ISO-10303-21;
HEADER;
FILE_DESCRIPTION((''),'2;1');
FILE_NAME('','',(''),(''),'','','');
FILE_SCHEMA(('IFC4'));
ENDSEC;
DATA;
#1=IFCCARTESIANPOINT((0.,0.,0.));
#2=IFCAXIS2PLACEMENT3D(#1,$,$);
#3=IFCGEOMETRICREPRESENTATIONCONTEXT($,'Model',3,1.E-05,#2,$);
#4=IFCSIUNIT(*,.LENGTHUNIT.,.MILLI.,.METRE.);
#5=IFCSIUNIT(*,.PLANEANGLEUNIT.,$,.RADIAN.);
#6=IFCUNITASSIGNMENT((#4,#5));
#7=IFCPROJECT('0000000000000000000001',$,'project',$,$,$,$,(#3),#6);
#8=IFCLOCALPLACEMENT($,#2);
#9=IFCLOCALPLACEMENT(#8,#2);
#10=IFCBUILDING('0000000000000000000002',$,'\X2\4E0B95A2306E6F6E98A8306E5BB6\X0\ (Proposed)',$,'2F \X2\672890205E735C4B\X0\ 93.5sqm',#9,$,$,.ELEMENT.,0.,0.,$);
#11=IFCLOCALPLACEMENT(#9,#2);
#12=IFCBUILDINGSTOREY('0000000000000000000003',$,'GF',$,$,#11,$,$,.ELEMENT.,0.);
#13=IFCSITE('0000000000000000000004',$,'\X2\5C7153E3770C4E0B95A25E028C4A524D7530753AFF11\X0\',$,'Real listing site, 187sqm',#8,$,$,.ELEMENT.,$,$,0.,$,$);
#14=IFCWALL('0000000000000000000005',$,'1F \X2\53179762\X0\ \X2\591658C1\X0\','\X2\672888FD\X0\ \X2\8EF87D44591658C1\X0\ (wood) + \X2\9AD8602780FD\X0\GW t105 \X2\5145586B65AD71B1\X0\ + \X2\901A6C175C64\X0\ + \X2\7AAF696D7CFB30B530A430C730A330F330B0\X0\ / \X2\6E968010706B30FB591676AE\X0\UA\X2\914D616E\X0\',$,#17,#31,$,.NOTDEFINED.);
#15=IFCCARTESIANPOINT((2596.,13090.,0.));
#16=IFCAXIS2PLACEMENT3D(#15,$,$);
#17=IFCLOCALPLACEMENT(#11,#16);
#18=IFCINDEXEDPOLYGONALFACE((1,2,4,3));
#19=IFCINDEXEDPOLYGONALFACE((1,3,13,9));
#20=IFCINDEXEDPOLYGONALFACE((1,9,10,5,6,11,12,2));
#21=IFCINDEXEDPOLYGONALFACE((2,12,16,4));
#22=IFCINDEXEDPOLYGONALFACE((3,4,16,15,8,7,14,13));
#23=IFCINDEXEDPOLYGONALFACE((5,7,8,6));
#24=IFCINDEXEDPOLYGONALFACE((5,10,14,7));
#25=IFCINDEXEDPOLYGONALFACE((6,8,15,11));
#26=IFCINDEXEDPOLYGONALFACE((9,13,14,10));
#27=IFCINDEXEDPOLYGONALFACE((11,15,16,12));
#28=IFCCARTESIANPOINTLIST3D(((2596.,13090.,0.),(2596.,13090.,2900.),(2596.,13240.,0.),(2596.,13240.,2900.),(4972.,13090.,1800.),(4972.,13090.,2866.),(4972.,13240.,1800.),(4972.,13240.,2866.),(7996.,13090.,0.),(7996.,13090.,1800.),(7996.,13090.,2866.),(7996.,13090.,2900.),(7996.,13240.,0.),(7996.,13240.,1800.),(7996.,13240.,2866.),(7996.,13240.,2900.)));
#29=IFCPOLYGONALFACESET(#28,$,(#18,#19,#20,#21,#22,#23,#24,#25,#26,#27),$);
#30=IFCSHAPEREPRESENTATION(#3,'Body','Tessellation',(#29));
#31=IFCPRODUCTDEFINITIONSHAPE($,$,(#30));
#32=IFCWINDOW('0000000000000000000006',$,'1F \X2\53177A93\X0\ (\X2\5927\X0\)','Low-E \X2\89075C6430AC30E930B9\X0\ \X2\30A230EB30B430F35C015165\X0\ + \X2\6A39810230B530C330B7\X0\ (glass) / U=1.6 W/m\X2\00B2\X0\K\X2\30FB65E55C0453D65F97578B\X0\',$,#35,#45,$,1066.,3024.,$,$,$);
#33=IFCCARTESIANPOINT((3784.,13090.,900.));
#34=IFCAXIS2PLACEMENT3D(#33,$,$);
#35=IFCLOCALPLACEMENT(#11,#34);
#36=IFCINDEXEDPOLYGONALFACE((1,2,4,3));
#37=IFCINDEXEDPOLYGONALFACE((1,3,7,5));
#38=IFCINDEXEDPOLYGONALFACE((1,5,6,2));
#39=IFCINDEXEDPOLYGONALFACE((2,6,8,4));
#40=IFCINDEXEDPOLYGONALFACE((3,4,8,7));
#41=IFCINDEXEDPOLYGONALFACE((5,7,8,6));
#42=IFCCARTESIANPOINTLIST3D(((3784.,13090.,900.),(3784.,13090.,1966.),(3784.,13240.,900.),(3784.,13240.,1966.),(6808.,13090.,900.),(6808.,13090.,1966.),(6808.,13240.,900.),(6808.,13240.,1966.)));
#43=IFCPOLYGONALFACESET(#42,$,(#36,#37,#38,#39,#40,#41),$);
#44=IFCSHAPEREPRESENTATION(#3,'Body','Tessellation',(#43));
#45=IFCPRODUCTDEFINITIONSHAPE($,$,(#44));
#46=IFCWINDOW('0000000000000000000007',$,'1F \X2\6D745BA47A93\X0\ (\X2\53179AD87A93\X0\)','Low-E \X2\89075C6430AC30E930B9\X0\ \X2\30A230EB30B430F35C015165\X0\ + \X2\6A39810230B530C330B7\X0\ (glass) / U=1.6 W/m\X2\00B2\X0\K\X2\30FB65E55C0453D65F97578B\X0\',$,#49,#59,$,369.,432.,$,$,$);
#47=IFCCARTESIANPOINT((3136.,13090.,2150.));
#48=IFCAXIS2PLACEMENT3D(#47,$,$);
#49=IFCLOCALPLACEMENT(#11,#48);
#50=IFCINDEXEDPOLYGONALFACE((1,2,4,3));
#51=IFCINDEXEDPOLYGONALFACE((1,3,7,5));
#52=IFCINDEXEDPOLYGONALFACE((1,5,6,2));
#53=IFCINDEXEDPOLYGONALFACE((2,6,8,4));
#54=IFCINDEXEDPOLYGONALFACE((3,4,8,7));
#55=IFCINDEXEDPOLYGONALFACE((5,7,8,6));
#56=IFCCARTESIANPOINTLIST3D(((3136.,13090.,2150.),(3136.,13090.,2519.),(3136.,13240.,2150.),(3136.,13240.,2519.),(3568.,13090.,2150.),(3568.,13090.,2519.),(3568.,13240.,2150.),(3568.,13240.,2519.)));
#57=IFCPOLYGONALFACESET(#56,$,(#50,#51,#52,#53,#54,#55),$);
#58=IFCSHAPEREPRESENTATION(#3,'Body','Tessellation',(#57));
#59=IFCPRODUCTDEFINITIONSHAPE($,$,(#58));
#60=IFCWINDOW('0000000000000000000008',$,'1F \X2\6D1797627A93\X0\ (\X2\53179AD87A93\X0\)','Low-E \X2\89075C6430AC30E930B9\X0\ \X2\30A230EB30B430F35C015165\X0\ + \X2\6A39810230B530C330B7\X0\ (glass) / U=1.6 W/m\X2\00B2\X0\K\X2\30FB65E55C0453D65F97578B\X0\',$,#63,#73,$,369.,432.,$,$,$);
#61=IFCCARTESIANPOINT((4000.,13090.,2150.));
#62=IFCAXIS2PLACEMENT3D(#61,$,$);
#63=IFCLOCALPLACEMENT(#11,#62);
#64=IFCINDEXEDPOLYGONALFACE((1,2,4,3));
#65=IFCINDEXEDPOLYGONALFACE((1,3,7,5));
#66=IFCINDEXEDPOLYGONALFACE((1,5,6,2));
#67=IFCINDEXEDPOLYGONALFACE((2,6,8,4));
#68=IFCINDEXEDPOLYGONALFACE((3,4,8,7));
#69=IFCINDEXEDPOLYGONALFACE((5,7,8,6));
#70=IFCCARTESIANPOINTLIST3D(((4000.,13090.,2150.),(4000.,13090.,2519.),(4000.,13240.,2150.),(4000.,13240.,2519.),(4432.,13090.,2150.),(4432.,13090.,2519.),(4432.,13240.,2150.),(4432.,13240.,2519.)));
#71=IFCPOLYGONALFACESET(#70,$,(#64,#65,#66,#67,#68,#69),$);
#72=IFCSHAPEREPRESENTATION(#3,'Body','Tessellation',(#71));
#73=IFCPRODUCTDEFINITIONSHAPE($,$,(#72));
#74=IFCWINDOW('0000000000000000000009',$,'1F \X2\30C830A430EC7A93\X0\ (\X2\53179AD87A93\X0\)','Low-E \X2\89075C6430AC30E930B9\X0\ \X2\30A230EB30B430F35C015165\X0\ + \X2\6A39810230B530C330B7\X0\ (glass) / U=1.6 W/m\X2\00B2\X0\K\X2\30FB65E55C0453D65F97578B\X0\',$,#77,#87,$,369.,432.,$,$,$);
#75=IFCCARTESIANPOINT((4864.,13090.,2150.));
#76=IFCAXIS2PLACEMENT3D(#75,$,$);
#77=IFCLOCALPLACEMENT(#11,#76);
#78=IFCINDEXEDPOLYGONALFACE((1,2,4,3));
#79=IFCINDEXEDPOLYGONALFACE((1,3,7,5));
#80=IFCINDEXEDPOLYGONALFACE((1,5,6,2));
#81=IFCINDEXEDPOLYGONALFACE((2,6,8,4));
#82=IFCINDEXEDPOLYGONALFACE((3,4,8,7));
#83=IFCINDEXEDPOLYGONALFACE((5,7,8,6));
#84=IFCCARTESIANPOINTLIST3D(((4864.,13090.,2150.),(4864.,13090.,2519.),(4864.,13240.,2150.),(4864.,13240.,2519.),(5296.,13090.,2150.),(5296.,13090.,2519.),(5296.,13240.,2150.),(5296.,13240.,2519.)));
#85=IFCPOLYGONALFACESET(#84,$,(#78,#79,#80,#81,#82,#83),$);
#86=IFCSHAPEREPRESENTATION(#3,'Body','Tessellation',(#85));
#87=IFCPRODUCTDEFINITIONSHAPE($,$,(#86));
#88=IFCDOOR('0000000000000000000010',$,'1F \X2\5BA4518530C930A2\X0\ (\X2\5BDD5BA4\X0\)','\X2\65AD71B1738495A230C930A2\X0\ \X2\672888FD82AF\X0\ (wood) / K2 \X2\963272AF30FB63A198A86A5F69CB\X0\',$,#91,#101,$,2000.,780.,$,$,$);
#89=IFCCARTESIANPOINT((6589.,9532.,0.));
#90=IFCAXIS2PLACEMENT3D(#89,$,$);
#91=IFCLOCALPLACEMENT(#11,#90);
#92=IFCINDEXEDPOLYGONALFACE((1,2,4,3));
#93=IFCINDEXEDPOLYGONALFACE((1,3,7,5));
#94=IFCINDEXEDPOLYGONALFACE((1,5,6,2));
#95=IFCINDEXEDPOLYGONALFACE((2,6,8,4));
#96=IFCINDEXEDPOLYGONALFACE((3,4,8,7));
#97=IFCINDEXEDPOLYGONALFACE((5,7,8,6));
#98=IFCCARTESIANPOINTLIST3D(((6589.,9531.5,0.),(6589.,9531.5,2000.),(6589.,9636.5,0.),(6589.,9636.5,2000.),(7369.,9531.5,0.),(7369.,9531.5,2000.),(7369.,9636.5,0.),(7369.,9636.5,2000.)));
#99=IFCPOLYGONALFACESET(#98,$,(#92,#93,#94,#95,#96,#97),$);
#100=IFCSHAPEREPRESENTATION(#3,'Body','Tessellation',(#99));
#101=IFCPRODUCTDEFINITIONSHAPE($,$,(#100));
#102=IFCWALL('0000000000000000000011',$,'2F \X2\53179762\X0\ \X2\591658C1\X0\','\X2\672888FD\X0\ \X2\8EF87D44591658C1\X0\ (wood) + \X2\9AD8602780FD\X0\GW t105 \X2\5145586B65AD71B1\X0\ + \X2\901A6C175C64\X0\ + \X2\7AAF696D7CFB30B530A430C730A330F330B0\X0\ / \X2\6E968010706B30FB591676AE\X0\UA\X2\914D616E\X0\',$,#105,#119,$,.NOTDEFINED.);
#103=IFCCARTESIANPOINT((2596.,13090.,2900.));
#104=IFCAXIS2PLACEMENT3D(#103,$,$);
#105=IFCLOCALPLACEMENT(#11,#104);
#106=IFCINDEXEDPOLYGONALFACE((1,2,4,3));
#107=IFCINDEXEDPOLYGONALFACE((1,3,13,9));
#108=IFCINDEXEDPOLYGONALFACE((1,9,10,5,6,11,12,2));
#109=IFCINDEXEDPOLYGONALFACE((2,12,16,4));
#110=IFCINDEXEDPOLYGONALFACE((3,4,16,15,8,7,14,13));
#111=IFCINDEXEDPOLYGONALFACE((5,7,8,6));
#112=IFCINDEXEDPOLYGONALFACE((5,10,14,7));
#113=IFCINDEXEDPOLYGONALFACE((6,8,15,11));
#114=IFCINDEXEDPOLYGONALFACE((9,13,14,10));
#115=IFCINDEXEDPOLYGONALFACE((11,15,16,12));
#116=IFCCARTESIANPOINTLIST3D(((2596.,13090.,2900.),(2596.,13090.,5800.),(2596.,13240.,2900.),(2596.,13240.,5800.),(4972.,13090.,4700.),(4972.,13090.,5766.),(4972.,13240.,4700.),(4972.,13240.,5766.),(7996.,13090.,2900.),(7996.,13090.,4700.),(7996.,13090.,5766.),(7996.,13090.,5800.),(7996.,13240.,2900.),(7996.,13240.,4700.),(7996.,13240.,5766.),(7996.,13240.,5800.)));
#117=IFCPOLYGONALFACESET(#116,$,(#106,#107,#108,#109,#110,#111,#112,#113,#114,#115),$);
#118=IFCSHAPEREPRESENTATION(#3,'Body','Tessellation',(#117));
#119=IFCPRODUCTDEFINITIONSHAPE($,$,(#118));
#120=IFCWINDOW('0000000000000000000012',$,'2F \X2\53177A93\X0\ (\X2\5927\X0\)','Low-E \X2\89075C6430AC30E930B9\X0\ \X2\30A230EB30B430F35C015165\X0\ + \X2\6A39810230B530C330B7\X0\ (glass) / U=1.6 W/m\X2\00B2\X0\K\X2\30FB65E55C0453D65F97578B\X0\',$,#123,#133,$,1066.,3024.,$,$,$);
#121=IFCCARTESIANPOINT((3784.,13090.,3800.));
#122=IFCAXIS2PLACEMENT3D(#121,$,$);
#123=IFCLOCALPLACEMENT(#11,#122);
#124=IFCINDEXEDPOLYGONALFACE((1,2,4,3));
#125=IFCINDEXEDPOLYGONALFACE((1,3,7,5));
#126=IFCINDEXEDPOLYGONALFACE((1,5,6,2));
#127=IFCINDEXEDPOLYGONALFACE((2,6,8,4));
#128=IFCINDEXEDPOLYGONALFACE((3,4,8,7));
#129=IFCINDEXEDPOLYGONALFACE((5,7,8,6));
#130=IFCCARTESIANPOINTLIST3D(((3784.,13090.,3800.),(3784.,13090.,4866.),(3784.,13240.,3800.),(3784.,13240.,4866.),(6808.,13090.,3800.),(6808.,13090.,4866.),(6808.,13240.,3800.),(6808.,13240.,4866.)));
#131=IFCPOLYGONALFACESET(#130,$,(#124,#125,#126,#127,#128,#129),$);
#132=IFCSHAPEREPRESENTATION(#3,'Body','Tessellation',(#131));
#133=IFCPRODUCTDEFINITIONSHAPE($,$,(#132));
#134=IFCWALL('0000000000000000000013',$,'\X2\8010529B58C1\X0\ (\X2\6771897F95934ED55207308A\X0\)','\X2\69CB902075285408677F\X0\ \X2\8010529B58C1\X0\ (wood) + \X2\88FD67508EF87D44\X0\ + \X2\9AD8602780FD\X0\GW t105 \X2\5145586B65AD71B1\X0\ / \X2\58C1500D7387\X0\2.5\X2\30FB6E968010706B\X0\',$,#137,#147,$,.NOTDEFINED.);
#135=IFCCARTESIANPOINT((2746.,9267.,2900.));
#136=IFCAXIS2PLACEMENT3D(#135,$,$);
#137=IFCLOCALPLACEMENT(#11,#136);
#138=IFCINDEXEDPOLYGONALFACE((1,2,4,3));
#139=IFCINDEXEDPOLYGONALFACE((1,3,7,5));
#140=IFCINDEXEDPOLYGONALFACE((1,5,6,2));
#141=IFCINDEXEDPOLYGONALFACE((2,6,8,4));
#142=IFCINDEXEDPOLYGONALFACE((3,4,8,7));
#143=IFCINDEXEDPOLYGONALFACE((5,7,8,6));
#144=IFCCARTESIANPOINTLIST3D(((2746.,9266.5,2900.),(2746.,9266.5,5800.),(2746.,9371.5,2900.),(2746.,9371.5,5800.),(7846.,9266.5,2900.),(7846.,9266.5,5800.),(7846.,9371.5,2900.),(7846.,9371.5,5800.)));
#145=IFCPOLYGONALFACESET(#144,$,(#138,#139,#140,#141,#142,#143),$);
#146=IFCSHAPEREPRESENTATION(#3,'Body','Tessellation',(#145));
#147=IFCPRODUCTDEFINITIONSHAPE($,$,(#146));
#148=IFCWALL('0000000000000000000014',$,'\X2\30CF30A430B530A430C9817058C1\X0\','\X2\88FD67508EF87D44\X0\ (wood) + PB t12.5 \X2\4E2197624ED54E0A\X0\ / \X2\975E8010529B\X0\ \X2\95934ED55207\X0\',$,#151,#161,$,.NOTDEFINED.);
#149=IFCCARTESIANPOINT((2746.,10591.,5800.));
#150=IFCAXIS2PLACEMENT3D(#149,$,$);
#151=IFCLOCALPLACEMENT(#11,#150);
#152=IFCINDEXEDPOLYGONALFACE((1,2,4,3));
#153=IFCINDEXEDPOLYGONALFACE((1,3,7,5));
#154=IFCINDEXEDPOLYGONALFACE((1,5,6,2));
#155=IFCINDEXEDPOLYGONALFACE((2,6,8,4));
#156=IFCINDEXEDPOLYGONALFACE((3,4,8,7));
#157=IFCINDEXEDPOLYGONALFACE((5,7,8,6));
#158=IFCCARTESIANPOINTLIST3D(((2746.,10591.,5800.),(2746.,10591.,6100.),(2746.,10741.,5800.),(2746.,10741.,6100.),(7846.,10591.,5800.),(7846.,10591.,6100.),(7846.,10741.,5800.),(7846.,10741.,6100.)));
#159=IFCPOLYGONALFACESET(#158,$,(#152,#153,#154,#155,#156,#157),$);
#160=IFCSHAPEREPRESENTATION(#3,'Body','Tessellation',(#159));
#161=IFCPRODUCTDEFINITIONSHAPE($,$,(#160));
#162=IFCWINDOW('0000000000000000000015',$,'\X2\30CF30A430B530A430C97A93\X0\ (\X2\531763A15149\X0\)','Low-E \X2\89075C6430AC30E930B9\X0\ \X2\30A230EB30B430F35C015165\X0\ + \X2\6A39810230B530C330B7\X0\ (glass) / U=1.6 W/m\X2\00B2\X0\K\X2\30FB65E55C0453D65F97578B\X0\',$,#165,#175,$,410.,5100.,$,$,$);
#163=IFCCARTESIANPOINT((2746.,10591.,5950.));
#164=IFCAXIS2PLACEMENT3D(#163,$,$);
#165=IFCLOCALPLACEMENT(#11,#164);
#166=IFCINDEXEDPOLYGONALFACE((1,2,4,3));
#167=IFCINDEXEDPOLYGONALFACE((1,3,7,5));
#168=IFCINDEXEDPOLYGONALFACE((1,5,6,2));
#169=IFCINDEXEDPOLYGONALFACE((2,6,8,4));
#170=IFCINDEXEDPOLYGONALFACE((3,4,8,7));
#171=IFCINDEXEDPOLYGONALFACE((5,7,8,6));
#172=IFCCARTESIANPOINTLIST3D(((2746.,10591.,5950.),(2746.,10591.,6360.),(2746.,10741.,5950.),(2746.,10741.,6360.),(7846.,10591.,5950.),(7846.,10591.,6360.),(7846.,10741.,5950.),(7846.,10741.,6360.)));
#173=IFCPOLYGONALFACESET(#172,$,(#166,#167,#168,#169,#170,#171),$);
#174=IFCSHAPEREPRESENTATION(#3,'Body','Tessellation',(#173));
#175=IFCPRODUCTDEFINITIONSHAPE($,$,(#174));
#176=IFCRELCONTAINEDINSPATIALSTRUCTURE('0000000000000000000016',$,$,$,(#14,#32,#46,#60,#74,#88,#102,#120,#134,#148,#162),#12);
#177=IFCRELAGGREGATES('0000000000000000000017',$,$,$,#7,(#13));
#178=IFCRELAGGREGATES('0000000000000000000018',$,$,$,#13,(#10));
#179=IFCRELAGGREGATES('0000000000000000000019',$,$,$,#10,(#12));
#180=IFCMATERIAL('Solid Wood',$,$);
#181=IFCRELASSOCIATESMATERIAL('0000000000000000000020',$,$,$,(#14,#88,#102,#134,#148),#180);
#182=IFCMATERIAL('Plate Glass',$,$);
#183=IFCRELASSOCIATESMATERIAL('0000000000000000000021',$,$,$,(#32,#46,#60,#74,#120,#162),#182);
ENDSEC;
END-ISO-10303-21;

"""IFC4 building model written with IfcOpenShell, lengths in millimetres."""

from ifc_helpers import new_model, si_unit, frame, frame_2d, origin, place, context, project, spatial, rectangle, extrude, material, element, fill, save


model = new_model("IFC4")

# Units and contexts
model_context = context("Model", 3, precision=1e-05, world=origin())
ifc_project = project(units=[si_unit("LENGTHUNIT", "METRE", prefix="MILLI"), si_unit("PLANEANGLEUNIT", "RADIAN")], contexts=[model_context])

# Site, building, storey
site_placement = place(None, origin())
site = spatial("IfcSite", under=ifc_project, at=site_placement, Name="山口県下関市豊前田町１", ObjectType="Real listing site, 187sqm", CompositionType="ELEMENT", RefElevation=0.0)
building_placement = place(site_placement, origin())
building = spatial("IfcBuilding", under=site, at=building_placement, Name="下関の潮風の家 (Proposed)", ObjectType="2F 木造平屋 93.5sqm", CompositionType="ELEMENT", ElevationOfRefHeight=0.0, ElevationOfTerrain=0.0)
storey_placement = place(building_placement, origin())
storey = spatial("IfcBuildingStorey", under=building, at=storey_placement, Name="GF", CompositionType="ELEMENT", Elevation=0.0)

# Wall, openings, windows
ifc_material_1 = material(Name="Solid Wood")
wall_1_placement = place(storey_placement, frame((2596.0, 13090.0, 0.0)))
wall_1 = element("IfcWall", 1, at=wall_1_placement, inside=storey, material=ifc_material_1, Name="1F 北面 外壁", Description="木製 軸組外壁 (wood) + 高性能GW t105 充填断熱 + 通気層 + 窯業系サイディング / 準耐火・外皮UA配慮", PredefinedType="NOTDEFINED", context=model_context, shape_type="SweptSolid", body=[
    extrude(rectangle(XDim=5400.0, YDim=150.0, at=frame_2d((2700.0, 75.0))), frame((2596.0, 13090.0, 0.0)), (0.0, 0.0, 1.0), 2900.0),
])
opening_1_placement = place(storey_placement, frame((3784.0, 13090.0, 900.0)))
opening_1 = element("IfcOpeningElement", 2, at=opening_1_placement, cuts=wall_1, PredefinedType="NOTDEFINED", context=model_context, shape_type="SweptSolid", body=[
    extrude(rectangle(XDim=3024.0, YDim=150.0, at=frame_2d((1512.0, 75.0))), frame((3784.0, 13090.0, 900.0)), (0.0, 0.0, 1.0), 1066.0),
])
opening_2_placement = place(storey_placement, frame((3136.0, 13090.0, 2150.0)))
opening_2 = element("IfcOpeningElement", 3, at=opening_2_placement, cuts=wall_1, PredefinedType="NOTDEFINED", context=model_context, shape_type="SweptSolid", body=[
    extrude(rectangle(XDim=432.0, YDim=150.0, at=frame_2d((216.0, 75.0))), frame((3136.0, 13090.0, 2150.0)), (0.0, 0.0, 1.0), 369.0),
])
opening_3_placement = place(storey_placement, frame((4000.0, 13090.0, 2150.0)))
opening_3 = element("IfcOpeningElement", 4, at=opening_3_placement, cuts=wall_1, PredefinedType="NOTDEFINED", context=model_context, shape_type="SweptSolid", body=[
    extrude(rectangle(XDim=432.0, YDim=150.0, at=frame_2d((216.0, 75.0))), frame((4000.0, 13090.0, 2150.0)), (0.0, 0.0, 1.0), 369.0),
])
opening_4_placement = place(storey_placement, frame((4864.0, 13090.0, 2150.0)))
opening_4 = element("IfcOpeningElement", 5, at=opening_4_placement, cuts=wall_1, PredefinedType="NOTDEFINED", context=model_context, shape_type="SweptSolid", body=[
    extrude(rectangle(XDim=432.0, YDim=150.0, at=frame_2d((216.0, 75.0))), frame((4864.0, 13090.0, 2150.0)), (0.0, 0.0, 1.0), 369.0),
])
ifc_material_2 = material(Name="Plate Glass")
window_1_placement = place(storey_placement, frame((3784.0, 13090.0, 900.0)))
window_1 = element("IfcWindow", 6, at=window_1_placement, inside=storey, material=ifc_material_2, Name="1F 北窓 (大)", Description="Low-E 複層ガラス アルゴン封入 + 樹脂サッシ (glass) / U=1.6 W/m²K・日射取得型", OverallHeight=1066.0, OverallWidth=3024.0, context=model_context, shape_type="SweptSolid", body=[
    extrude(rectangle(XDim=3024.0, YDim=150.0, at=frame_2d((1512.0, 75.0))), frame((3784.0, 13090.0, 900.0)), (0.0, 0.0, 1.0), 1066.0),
])
fill(opening_1, window_1)
window_2_placement = place(storey_placement, frame((3136.0, 13090.0, 2150.0)))
window_2 = element("IfcWindow", 7, at=window_2_placement, inside=storey, material=ifc_material_2, Name="1F 浴室窓 (北高窓)", Description="Low-E 複層ガラス アルゴン封入 + 樹脂サッシ (glass) / U=1.6 W/m²K・日射取得型", OverallHeight=369.0, OverallWidth=432.0, context=model_context, shape_type="SweptSolid", body=[
    extrude(rectangle(XDim=432.0, YDim=150.0, at=frame_2d((216.0, 75.0))), frame((3136.0, 13090.0, 2150.0)), (0.0, 0.0, 1.0), 369.0),
])
fill(opening_2, window_2)
window_3_placement = place(storey_placement, frame((4000.0, 13090.0, 2150.0)))
window_3 = element("IfcWindow", 8, at=window_3_placement, inside=storey, material=ifc_material_2, Name="1F 洗面窓 (北高窓)", Description="Low-E 複層ガラス アルゴン封入 + 樹脂サッシ (glass) / U=1.6 W/m²K・日射取得型", OverallHeight=369.0, OverallWidth=432.0, context=model_context, shape_type="SweptSolid", body=[
    extrude(rectangle(XDim=432.0, YDim=150.0, at=frame_2d((216.0, 75.0))), frame((4000.0, 13090.0, 2150.0)), (0.0, 0.0, 1.0), 369.0),
])
fill(opening_3, window_3)
window_4_placement = place(storey_placement, frame((4864.0, 13090.0, 2150.0)))
window_4 = element("IfcWindow", 9, at=window_4_placement, inside=storey, material=ifc_material_2, Name="1F トイレ窓 (北高窓)", Description="Low-E 複層ガラス アルゴン封入 + 樹脂サッシ (glass) / U=1.6 W/m²K・日射取得型", OverallHeight=369.0, OverallWidth=432.0, context=model_context, shape_type="SweptSolid", body=[
    extrude(rectangle(XDim=432.0, YDim=150.0, at=frame_2d((216.0, 75.0))), frame((4864.0, 13090.0, 2150.0)), (0.0, 0.0, 1.0), 369.0),
])
fill(opening_4, window_4)

# Door
door_1_placement = place(storey_placement, frame((6589.0, 9532.0, 0.0)))
element("IfcDoor", 10, at=door_1_placement, inside=storey, material=ifc_material_1, Name="1F 室内ドア (寝室)", Description="断熱玄関ドア 木製芯 (wood) / K2 防犯・採風機構", OverallHeight=2000.0, OverallWidth=780.0, context=model_context, shape_type="SweptSolid", body=[
    extrude(rectangle(XDim=780.0, YDim=105.0, at=frame_2d((390.0, 52.0))), frame((6589.0, 9532.0, 0.0)), (0.0, 0.0, 1.0), 2000.0),
])

# Wall, opening, window
wall_2_placement = place(storey_placement, frame((2596.0, 13090.0, 2900.0)))
wall_2 = element("IfcWall", 11, at=wall_2_placement, inside=storey, material=ifc_material_1, Name="2F 北面 外壁", Description="木製 軸組外壁 (wood) + 高性能GW t105 充填断熱 + 通気層 + 窯業系サイディング / 準耐火・外皮UA配慮", PredefinedType="NOTDEFINED", context=model_context, shape_type="SweptSolid", body=[
    extrude(rectangle(XDim=5400.0, YDim=150.0, at=frame_2d((2700.0, 75.0))), frame((2596.0, 13090.0, 2900.0)), (0.0, 0.0, 1.0), 2900.0),
])
opening_5_placement = place(storey_placement, frame((3784.0, 13090.0, 3800.0)))
opening_5 = element("IfcOpeningElement", 12, at=opening_5_placement, cuts=wall_2, PredefinedType="NOTDEFINED", context=model_context, shape_type="SweptSolid", body=[
    extrude(rectangle(XDim=3024.0, YDim=150.0, at=frame_2d((1512.0, 75.0))), frame((3784.0, 13090.0, 3800.0)), (0.0, 0.0, 1.0), 1066.0),
])
window_5_placement = place(storey_placement, frame((3784.0, 13090.0, 3800.0)))
window_5 = element("IfcWindow", 13, at=window_5_placement, inside=storey, material=ifc_material_2, Name="2F 北窓 (大)", Description="Low-E 複層ガラス アルゴン封入 + 樹脂サッシ (glass) / U=1.6 W/m²K・日射取得型", OverallHeight=1066.0, OverallWidth=3024.0, context=model_context, shape_type="SweptSolid", body=[
    extrude(rectangle(XDim=3024.0, YDim=150.0, at=frame_2d((1512.0, 75.0))), frame((3784.0, 13090.0, 3800.0)), (0.0, 0.0, 1.0), 1066.0),
])
fill(opening_5, window_5)

# Wall
wall_3_placement = place(storey_placement, frame((2746.0, 9267.0, 2900.0)))
element("IfcWall", 14, at=wall_3_placement, inside=storey, material=ifc_material_1, Name="耐力壁 (東西間仕切り)", Description="構造用合板 耐力壁 (wood) + 製材軸組 + 高性能GW t105 充填断熱 / 壁倍率2.5・準耐火", PredefinedType="NOTDEFINED", context=model_context, shape_type="SweptSolid", body=[
    extrude(rectangle(XDim=5100.0, YDim=105.0, at=frame_2d((2550.0, 52.0))), frame((2746.0, 9267.0, 2900.0)), (0.0, 0.0, 1.0), 2900.0),
])

# Wall, opening, window
wall_4_placement = place(storey_placement, frame((2746.0, 10591.0, 5800.0)))
wall_4 = element("IfcWall", 15, at=wall_4_placement, inside=storey, material=ifc_material_1, Name="ハイサイド腰壁", Description="製材軸組 (wood) + PB t12.5 両面仕上 / 非耐力 間仕切", PredefinedType="NOTDEFINED", context=model_context, shape_type="SweptSolid", body=[
    extrude(rectangle(XDim=5100.0, YDim=150.0, at=frame_2d((2550.0, 75.0))), frame((2746.0, 10591.0, 5800.0)), (0.0, 0.0, 1.0), 700.0),
])
opening_6_placement = place(storey_placement, frame((2746.0, 10591.0, 5950.0)))
opening_6 = element("IfcOpeningElement", 16, at=opening_6_placement, cuts=wall_4, PredefinedType="NOTDEFINED", context=model_context, shape_type="SweptSolid", body=[
    extrude(rectangle(XDim=5100.0, YDim=150.0, at=frame_2d((2550.0, 75.0))), frame((2746.0, 10591.0, 5950.0)), (0.0, 0.0, 1.0), 410.0),
])
window_6_placement = place(storey_placement, frame((2746.0, 10591.0, 5950.0)))
window_6 = element("IfcWindow", 17, at=window_6_placement, inside=storey, material=ifc_material_2, Name="ハイサイド窓 (北採光)", Description="Low-E 複層ガラス アルゴン封入 + 樹脂サッシ (glass) / U=1.6 W/m²K・日射取得型", OverallHeight=410.0, OverallWidth=5100.0, context=model_context, shape_type="SweptSolid", body=[
    extrude(rectangle(XDim=5100.0, YDim=150.0, at=frame_2d((2550.0, 75.0))), frame((2746.0, 10591.0, 5950.0)), (0.0, 0.0, 1.0), 410.0),
])
fill(opening_6, window_6)

save(model, "model.ifc")
